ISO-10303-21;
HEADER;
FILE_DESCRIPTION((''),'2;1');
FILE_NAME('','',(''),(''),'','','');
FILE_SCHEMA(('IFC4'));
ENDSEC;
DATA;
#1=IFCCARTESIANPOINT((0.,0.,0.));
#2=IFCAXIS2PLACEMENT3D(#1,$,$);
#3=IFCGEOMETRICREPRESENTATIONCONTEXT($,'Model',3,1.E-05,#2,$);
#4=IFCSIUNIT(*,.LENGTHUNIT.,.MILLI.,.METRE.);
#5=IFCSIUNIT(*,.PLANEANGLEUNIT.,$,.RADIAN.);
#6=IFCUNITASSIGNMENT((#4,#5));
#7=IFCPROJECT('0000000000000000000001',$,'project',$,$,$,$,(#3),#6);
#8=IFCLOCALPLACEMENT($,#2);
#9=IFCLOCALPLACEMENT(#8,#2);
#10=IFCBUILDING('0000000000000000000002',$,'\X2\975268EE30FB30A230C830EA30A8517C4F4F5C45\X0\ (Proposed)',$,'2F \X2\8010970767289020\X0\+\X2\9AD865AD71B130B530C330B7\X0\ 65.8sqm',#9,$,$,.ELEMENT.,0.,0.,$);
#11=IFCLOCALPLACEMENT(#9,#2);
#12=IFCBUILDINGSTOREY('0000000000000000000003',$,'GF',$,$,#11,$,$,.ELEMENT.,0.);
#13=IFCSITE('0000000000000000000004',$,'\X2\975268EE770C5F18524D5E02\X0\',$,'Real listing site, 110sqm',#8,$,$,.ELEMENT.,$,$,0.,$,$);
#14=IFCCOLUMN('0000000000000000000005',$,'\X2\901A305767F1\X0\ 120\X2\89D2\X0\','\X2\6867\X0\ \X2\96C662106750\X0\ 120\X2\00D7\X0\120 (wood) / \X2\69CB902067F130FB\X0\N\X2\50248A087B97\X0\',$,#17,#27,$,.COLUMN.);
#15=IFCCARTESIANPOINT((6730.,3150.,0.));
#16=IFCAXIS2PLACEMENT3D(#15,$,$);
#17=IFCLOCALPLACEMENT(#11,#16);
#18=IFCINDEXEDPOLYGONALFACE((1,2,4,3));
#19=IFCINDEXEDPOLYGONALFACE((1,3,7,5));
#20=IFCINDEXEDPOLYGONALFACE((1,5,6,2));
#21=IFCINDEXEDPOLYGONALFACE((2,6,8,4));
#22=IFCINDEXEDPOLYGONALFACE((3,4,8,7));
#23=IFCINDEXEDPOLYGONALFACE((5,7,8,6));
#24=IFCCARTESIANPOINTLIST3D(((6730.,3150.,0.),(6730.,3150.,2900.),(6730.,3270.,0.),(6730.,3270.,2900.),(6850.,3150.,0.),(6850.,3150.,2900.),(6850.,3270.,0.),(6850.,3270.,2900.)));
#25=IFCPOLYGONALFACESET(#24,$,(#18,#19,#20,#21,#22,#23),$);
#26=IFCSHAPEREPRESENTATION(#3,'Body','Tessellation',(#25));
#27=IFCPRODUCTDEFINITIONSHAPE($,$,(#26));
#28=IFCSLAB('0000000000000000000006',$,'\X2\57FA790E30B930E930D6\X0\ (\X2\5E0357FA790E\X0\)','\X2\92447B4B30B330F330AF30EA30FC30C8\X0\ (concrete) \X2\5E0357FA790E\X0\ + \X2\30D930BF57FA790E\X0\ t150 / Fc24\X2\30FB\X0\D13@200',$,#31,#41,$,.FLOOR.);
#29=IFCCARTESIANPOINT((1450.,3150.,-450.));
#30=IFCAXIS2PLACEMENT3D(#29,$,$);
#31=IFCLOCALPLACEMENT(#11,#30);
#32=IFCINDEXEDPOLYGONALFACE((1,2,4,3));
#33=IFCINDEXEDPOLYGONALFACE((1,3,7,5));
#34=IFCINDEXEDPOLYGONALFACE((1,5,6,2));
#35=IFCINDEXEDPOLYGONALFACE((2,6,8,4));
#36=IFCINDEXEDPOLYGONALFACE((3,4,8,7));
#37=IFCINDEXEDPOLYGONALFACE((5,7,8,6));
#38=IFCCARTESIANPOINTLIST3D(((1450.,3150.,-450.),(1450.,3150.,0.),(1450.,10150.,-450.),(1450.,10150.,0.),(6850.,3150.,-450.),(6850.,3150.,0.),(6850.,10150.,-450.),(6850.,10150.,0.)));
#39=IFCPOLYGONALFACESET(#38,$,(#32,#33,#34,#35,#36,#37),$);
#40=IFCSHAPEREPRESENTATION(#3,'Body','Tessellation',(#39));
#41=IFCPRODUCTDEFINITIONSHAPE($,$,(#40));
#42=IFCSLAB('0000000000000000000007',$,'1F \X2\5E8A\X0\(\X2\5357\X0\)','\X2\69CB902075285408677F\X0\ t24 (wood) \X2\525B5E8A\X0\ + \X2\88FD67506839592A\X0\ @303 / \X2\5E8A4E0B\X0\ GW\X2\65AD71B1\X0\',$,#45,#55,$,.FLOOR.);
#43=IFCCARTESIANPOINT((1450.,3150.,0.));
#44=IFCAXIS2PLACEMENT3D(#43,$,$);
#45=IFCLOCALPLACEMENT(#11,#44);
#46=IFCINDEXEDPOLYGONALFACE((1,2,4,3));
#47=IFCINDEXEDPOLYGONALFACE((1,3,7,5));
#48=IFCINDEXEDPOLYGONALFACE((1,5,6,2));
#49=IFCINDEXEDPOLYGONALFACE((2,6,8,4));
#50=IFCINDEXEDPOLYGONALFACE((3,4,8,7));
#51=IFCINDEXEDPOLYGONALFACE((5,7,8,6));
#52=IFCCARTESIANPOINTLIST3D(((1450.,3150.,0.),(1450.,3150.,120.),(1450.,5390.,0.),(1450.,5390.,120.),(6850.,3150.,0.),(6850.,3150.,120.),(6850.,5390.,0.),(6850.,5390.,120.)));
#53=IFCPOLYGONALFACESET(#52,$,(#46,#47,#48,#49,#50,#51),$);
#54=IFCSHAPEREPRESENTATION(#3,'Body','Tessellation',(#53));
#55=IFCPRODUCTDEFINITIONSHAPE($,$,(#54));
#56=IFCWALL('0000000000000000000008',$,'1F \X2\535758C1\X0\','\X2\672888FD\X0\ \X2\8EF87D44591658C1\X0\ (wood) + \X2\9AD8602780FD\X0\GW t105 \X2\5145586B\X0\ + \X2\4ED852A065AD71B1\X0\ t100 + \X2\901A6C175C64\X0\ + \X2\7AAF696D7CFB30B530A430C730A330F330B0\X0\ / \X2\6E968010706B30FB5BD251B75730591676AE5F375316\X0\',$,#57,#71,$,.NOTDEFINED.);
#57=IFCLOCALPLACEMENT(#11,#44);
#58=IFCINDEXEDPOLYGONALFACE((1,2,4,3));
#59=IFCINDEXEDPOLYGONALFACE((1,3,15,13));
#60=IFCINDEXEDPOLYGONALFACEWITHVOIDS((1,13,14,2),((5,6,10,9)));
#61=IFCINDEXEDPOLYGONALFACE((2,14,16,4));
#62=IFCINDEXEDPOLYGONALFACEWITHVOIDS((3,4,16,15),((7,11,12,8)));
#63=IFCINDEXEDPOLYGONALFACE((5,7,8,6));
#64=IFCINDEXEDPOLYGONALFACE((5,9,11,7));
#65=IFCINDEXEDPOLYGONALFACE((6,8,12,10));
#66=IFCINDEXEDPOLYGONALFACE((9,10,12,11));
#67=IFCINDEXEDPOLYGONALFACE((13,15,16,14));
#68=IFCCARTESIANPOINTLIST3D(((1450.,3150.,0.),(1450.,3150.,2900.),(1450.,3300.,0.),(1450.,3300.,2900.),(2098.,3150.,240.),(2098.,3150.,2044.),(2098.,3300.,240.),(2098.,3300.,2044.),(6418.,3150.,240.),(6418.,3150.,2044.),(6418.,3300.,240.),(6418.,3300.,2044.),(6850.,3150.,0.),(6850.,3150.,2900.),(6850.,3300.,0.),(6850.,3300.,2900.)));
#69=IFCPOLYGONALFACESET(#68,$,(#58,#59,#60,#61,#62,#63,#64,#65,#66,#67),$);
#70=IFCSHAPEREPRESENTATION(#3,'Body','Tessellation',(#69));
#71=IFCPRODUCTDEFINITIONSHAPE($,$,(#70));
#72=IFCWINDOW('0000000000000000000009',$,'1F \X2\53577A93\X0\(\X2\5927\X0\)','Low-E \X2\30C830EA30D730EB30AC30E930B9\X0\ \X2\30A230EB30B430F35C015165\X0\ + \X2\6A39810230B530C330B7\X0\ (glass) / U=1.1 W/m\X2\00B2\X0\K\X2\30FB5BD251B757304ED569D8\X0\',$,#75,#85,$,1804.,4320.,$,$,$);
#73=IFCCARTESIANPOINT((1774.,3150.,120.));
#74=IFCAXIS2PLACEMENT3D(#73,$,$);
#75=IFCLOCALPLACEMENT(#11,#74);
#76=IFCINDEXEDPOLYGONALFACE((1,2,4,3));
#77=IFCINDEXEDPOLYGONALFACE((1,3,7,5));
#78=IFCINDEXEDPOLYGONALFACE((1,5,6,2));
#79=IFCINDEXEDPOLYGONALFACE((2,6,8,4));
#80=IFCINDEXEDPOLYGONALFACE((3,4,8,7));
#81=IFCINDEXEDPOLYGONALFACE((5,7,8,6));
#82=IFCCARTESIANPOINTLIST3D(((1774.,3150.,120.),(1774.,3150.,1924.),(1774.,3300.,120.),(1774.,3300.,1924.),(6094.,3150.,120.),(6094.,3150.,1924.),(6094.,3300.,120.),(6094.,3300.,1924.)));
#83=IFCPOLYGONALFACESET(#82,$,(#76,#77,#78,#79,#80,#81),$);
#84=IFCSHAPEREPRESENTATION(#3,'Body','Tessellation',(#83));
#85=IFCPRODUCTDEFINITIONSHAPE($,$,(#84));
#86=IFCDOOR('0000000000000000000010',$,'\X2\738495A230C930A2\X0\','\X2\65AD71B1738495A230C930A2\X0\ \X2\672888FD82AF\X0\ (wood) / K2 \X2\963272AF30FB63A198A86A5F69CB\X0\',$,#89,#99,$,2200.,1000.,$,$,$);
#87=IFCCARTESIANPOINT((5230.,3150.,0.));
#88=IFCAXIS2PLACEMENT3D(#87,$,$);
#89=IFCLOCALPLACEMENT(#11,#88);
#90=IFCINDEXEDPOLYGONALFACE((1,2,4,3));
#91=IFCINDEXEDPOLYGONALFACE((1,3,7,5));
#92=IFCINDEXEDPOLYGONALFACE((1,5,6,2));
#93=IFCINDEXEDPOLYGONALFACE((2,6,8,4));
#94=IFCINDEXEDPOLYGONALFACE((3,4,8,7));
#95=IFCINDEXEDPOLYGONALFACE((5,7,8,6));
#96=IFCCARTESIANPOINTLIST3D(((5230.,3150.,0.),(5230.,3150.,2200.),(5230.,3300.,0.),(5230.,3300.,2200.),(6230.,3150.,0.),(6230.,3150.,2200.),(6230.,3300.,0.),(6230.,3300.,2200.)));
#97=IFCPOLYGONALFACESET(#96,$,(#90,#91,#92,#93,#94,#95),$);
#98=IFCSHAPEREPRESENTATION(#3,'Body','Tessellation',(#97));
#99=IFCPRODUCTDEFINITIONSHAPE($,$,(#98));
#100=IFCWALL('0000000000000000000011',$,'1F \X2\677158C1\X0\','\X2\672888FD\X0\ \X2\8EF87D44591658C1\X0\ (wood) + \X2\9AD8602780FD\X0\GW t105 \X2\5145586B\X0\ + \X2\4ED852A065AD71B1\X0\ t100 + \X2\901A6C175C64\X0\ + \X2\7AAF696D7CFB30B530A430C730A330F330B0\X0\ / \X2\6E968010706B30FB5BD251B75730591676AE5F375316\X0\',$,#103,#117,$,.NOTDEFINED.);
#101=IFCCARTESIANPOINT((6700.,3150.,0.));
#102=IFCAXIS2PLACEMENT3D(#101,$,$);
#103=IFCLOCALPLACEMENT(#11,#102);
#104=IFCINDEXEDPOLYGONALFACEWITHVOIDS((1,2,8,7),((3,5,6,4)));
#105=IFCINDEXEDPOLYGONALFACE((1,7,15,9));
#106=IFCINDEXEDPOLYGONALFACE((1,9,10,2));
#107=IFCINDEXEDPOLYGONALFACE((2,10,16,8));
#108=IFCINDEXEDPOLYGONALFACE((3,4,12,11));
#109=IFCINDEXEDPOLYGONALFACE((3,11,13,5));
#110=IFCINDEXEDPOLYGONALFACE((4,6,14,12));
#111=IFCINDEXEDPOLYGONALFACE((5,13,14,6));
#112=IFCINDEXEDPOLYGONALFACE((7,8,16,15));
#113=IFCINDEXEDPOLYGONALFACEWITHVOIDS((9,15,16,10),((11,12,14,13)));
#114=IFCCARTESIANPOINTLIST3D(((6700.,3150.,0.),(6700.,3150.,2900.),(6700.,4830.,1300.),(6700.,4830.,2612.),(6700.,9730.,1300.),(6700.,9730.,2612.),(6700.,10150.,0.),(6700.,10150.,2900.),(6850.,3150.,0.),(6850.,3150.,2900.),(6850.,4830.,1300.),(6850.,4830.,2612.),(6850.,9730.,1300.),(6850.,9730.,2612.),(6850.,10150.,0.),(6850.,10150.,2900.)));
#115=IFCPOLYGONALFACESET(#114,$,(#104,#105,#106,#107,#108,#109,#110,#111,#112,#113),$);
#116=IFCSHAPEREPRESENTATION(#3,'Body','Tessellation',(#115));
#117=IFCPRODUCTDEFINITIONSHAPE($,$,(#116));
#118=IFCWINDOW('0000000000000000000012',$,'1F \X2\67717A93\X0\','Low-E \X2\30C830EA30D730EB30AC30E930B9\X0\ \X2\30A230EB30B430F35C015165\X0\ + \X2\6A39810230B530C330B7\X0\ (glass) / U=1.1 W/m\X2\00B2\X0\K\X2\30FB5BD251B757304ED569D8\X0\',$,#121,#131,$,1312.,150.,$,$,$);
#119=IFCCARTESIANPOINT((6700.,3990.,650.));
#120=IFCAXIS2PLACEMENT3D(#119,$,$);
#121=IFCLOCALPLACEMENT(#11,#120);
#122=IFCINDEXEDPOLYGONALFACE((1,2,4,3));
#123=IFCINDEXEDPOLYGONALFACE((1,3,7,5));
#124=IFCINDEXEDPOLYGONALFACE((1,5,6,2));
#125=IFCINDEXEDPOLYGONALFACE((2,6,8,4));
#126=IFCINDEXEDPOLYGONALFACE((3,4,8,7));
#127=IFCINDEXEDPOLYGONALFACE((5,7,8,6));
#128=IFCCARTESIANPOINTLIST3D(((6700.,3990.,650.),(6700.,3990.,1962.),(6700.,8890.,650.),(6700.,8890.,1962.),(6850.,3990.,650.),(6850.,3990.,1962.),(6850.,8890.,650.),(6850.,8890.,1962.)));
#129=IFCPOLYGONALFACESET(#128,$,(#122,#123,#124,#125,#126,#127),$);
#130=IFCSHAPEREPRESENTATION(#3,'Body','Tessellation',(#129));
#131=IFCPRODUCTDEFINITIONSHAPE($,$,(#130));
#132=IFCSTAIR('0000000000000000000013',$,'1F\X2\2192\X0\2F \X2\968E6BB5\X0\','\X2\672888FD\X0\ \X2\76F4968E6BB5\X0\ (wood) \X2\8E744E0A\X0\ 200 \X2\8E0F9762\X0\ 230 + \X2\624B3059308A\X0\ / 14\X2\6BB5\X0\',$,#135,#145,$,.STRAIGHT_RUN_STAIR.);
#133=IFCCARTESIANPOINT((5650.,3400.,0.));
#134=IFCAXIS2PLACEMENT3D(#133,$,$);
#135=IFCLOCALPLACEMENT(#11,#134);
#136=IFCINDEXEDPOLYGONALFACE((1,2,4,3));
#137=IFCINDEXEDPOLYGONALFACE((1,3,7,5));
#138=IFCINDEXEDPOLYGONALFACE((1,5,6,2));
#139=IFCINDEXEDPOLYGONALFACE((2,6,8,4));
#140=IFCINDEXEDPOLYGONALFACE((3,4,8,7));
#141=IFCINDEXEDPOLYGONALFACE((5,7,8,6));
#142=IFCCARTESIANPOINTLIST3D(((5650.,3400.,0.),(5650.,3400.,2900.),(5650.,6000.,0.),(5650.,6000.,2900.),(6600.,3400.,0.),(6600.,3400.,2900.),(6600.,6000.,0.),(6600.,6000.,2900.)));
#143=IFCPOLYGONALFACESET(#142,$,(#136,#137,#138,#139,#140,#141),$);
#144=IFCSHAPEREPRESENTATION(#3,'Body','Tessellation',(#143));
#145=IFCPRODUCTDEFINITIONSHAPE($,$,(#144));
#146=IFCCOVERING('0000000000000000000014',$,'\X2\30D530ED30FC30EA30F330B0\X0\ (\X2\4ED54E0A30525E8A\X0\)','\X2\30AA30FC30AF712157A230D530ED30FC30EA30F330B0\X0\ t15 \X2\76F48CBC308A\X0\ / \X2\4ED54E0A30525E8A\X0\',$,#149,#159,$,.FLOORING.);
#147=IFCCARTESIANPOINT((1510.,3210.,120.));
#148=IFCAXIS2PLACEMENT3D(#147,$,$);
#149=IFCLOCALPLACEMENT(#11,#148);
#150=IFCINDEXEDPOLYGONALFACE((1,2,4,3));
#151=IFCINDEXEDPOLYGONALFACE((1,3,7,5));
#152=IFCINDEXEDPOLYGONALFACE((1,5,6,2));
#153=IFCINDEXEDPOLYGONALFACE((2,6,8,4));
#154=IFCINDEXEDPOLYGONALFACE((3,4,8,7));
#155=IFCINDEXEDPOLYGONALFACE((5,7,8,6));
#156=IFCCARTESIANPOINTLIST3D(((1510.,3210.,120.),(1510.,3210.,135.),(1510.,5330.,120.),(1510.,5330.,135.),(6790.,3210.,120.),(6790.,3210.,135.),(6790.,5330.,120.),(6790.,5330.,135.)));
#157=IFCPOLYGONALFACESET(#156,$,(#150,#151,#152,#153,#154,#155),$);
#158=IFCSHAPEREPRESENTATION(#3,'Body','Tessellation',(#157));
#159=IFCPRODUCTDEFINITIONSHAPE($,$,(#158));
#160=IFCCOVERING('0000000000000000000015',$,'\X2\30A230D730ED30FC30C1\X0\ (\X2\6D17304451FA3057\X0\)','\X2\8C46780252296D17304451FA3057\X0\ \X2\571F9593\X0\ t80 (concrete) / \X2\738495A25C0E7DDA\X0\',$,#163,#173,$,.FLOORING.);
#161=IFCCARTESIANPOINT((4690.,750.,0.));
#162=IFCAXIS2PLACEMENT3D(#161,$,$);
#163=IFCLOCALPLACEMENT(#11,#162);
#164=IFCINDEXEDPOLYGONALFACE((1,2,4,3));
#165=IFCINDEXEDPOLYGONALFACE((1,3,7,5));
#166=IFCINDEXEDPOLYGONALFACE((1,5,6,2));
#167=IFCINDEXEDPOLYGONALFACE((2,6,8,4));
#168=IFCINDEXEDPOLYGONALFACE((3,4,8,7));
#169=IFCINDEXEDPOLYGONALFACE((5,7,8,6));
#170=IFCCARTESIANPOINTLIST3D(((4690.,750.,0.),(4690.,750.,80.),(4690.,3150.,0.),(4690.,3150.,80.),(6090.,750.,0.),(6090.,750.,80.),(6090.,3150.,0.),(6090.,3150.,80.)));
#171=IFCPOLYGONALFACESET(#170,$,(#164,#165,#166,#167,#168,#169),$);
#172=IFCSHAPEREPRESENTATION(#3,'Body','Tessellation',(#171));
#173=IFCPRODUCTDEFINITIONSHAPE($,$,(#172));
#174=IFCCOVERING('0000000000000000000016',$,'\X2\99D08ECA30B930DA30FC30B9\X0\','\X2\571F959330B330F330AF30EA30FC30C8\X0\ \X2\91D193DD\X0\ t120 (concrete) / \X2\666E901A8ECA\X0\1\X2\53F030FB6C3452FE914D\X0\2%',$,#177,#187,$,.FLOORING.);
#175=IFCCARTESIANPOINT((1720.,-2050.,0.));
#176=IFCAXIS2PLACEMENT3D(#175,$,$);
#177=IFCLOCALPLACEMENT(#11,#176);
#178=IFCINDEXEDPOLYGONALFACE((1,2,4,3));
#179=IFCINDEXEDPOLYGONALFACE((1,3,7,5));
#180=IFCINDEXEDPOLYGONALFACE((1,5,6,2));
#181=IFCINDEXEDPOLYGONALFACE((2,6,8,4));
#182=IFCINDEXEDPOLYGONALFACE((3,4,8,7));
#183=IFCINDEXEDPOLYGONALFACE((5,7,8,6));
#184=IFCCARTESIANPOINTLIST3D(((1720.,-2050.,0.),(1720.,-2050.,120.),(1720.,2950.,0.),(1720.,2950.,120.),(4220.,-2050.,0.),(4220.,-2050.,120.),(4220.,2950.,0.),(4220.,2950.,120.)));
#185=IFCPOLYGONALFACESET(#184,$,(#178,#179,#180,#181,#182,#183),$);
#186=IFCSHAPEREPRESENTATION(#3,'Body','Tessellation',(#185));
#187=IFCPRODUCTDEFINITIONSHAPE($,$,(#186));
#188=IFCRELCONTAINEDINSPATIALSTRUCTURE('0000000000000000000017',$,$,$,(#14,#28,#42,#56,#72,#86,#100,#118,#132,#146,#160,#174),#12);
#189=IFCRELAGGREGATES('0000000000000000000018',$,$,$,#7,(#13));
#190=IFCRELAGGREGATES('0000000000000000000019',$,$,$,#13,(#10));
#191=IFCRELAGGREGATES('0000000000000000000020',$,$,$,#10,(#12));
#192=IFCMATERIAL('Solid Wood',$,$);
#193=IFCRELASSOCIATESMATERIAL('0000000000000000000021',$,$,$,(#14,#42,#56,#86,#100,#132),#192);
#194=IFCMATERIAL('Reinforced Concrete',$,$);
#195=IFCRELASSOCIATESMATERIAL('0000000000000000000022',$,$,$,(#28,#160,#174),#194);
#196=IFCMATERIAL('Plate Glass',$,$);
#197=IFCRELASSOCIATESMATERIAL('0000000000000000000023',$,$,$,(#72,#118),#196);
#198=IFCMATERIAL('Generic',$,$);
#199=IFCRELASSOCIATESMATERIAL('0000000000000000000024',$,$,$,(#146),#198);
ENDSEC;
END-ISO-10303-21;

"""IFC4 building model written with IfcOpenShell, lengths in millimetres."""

from ifc_helpers import new_model, si_unit, frame, frame_2d, origin, place, context, project, spatial, rectangle, extrude, material, element, fill, save


model = new_model("IFC4")

# Units and contexts
model_context = context("Model", 3, precision=1e-05, world=origin())
ifc_project = project(units=[si_unit("LENGTHUNIT", "METRE", prefix="MILLI"), si_unit("PLANEANGLEUNIT", "RADIAN")], contexts=[model_context])

# Site, building, storey
site_placement = place(None, origin())
site = spatial("IfcSite", under=ifc_project, at=site_placement, Name="青森県弘前市", ObjectType="Real listing site, 110sqm", CompositionType="ELEMENT", RefElevation=0.0)
building_placement = place(site_placement, origin())
building = spatial("IfcBuilding", under=site, at=building_placement, Name="青森・アトリエ兼住居 (Proposed)", ObjectType="2F 耐震木造+高断熱サッシ 65.8sqm", CompositionType="ELEMENT", ElevationOfRefHeight=0.0, ElevationOfTerrain=0.0)
storey_placement = place(building_placement, origin())
storey = spatial("IfcBuildingStorey", under=building, at=storey_placement, Name="GF", CompositionType="ELEMENT", Elevation=0.0)

# Column
ifc_material_1 = material(Name="Solid Wood")
column_1_placement = place(storey_placement, frame((6730.0, 3150.0, 0.0)))
element("IfcColumn", 1, at=column_1_placement, inside=storey, material=ifc_material_1, Name="通し柱 120角", Description="桧 集成材 120×120 (wood) / 構造柱・N値計算", PredefinedType="COLUMN", context=model_context, shape_type="SweptSolid", body=[
    extrude(rectangle(XDim=120.0, YDim=120.0, at=frame_2d((60.0, 60.0))), frame((6730.0, 3150.0, 0.0)), (0.0, 0.0, 1.0), 2900.0),
])

# Slabs
ifc_material_2 = material(Name="Reinforced Concrete")
slab_1_placement = place(storey_placement, frame((1450.0, 3150.0, -450.0)))
element("IfcSlab", 2, at=slab_1_placement, inside=storey, material=ifc_material_2, Name="基礎スラブ (布基礎)", Description="鉄筋コンクリート (concrete) 布基礎 + ベタ基礎 t150 / Fc24・D13@200", PredefinedType="FLOOR", context=model_context, shape_type="SweptSolid", body=[
    extrude(rectangle(XDim=5400.0, YDim=7000.0, at=frame_2d((2700.0, 3500.0))), frame((1450.0, 3150.0, -450.0)), (0.0, 0.0, 1.0), 450.0),
])
slab_2_placement = place(storey_placement, frame((1450.0, 3150.0, 0.0)))
element("IfcSlab", 3, at=slab_2_placement, inside=storey, material=ifc_material_1, Name="1F 床(南)", Description="構造用合板 t24 (wood) 剛床 + 製材根太 @303 / 床下 GW断熱", PredefinedType="FLOOR", context=model_context, shape_type="SweptSolid", body=[
    extrude(rectangle(XDim=5400.0, YDim=2240.0, at=frame_2d((2700.0, 1120.0))), frame((1450.0, 3150.0, 0.0)), (0.0, 0.0, 1.0), 120.0),
])

# Wall, openings, window, door
wall_1_placement = place(storey_placement, frame((1450.0, 3150.0, 0.0)))
wall_1 = element("IfcWall", 4, at=wall_1_placement, inside=storey, material=ifc_material_1, Name="1F 南壁", Description="木製 軸組外壁 (wood) + 高性能GW t105 充填 + 付加断熱 t100 + 通気層 + 窯業系サイディング / 準耐火・寒冷地外皮強化", PredefinedType="NOTDEFINED", context=model_context, shape_type="SweptSolid", body=[
    extrude(rectangle(XDim=5400.0, YDim=150.0, at=frame_2d((2700.0, 75.0))), frame((1450.0, 3150.0, 0.0)), (0.0, 0.0, 1.0), 2900.0),
])
opening_1_placement = place(storey_placement, frame((1774.0, 3150.0, 120.0)))
opening_1 = element("IfcOpeningElement", 5, at=opening_1_placement, cuts=wall_1, PredefinedType="NOTDEFINED", context=model_context, shape_type="SweptSolid", body=[
    extrude(rectangle(XDim=4320.0, YDim=150.0, at=frame_2d((2160.0, 75.0))), frame((1774.0, 3150.0, 120.0)), (0.0, 0.0, 1.0), 1804.0),
])
opening_2_placement = place(storey_placement, frame((5230.0, 3150.0, 0.0)))
opening_2 = element("IfcOpeningElement", 6, at=opening_2_placement, cuts=wall_1, PredefinedType="NOTDEFINED", context=model_context, shape_type="SweptSolid", body=[
    extrude(rectangle(XDim=1000.0, YDim=150.0, at=frame_2d((500.0, 75.0))), frame((5230.0, 3150.0, 0.0)), (0.0, 0.0, 1.0), 2200.0),
])
ifc_material_3 = material(Name="Plate Glass")
window_1_placement = place(storey_placement, frame((1774.0, 3150.0, 120.0)))
window_1 = element("IfcWindow", 7, at=window_1_placement, inside=storey, material=ifc_material_3, Name="1F 南窓(大)", Description="Low-E トリプルガラス アルゴン封入 + 樹脂サッシ (glass) / U=1.1 W/m²K・寒冷地仕様", OverallHeight=1804.0, OverallWidth=4320.0, context=model_context, shape_type="SweptSolid", body=[
    extrude(rectangle(XDim=4320.0, YDim=150.0, at=frame_2d((2160.0, 75.0))), frame((1774.0, 3150.0, 120.0)), (0.0, 0.0, 1.0), 1804.0),
])
fill(opening_1, window_1)
door_placement = place(storey_placement, frame((5230.0, 3150.0, 0.0)))
door = element("IfcDoor", 8, at=door_placement, inside=storey, material=ifc_material_1, Name="玄関ドア", Description="断熱玄関ドア 木製芯 (wood) / K2 防犯・採風機構", OverallHeight=2200.0, OverallWidth=1000.0, context=model_context, shape_type="SweptSolid", body=[
    extrude(rectangle(XDim=1000.0, YDim=150.0, at=frame_2d((500.0, 75.0))), frame((5230.0, 3150.0, 0.0)), (0.0, 0.0, 1.0), 2200.0),
])
fill(opening_2, door)

# Wall, opening, window
wall_2_placement = place(storey_placement, frame((6700.0, 3150.0, 0.0)))
wall_2 = element("IfcWall", 9, at=wall_2_placement, inside=storey, material=ifc_material_1, Name="1F 東壁", Description="木製 軸組外壁 (wood) + 高性能GW t105 充填 + 付加断熱 t100 + 通気層 + 窯業系サイディング / 準耐火・寒冷地外皮強化", PredefinedType="NOTDEFINED", context=model_context, shape_type="SweptSolid", body=[
    extrude(rectangle(XDim=150.0, YDim=7000.0, at=frame_2d((75.0, 3500.0))), frame((6700.0, 3150.0, 0.0)), (0.0, 0.0, 1.0), 2900.0),
])
opening_3_placement = place(storey_placement, frame((6700.0, 3990.0, 650.0)))
opening_3 = element("IfcOpeningElement", 10, at=opening_3_placement, cuts=wall_2, PredefinedType="NOTDEFINED", context=model_context, shape_type="SweptSolid", body=[
    extrude(rectangle(XDim=150.0, YDim=4900.0, at=frame_2d((75.0, 2450.0))), frame((6700.0, 3990.0, 650.0)), (0.0, 0.0, 1.0), 1312.0),
])
window_2_placement = place(storey_placement, frame((6700.0, 3990.0, 650.0)))
window_2 = element("IfcWindow", 11, at=window_2_placement, inside=storey, material=ifc_material_3, Name="1F 東窓", Description="Low-E トリプルガラス アルゴン封入 + 樹脂サッシ (glass) / U=1.1 W/m²K・寒冷地仕様", OverallHeight=1312.0, OverallWidth=150.0, context=model_context, shape_type="SweptSolid", body=[
    extrude(rectangle(XDim=150.0, YDim=4900.0, at=frame_2d((75.0, 2450.0))), frame((6700.0, 3990.0, 650.0)), (0.0, 0.0, 1.0), 1312.0),
])
fill(opening_3, window_2)

# Stair
stair_placement = place(storey_placement, frame((5650.0, 3400.0, 0.0)))
element("IfcStair", 12, at=stair_placement, inside=storey, material=ifc_material_1, Name="1F→2F 階段", Description="木製 直階段 (wood) 蹴上 200 踏面 230 + 手すり / 14段", PredefinedType="STRAIGHT_RUN_STAIR", context=model_context, shape_type="SweptSolid", body=[
    extrude(rectangle(XDim=950.0, YDim=2600.0, at=frame_2d((475.0, 1300.0))), frame((5650.0, 3400.0, 0.0)), (0.0, 0.0, 1.0), 2900.0),
])

# Coverings
ifc_material_4 = material(Name="Generic")
covering_1_placement = place(storey_placement, frame((1510.0, 3210.0, 120.0)))
element("IfcCovering", 13, at=covering_1_placement, inside=storey, material=ifc_material_4, Name="フローリング (仕上げ床)", Description="オーク無垢フローリング t15 直貼り / 仕上げ床", PredefinedType="FLOORING", context=model_context, shape_type="SweptSolid", body=[
    extrude(rectangle(XDim=5280.0, YDim=2120.0, at=frame_2d((2640.0, 1060.0))), frame((1510.0, 3210.0, 120.0)), (0.0, 0.0, 1.0), 15.0),
])
covering_2_placement = place(storey_placement, frame((4690.0, 750.0, 0.0)))
element("IfcCovering", 14, at=covering_2_placement, inside=storey, material=ifc_material_2, Name="アプローチ (洗い出し)", Description="豆砂利洗い出し 土間 t80 (concrete) / 玄関導線", PredefinedType="FLOORING", context=model_context, shape_type="SweptSolid", body=[
    extrude(rectangle(XDim=1400.0, YDim=2400.0, at=frame_2d((700.0, 1200.0))), frame((4690.0, 750.0, 0.0)), (0.0, 0.0, 1.0), 80.0),
])
covering_3_placement = place(storey_placement, frame((1720.0, -2050.0, 0.0)))
element("IfcCovering", 15, at=covering_3_placement, inside=storey, material=ifc_material_2, Name="駐車スペース", Description="土間コンクリート 金鏝 t120 (concrete) / 普通車1台・水勾配2%", PredefinedType="FLOORING", context=model_context, shape_type="SweptSolid", body=[
    extrude(rectangle(XDim=2500.0, YDim=5000.0, at=frame_2d((1250.0, 2500.0))), frame((1720.0, -2050.0, 0.0)), (0.0, 0.0, 1.0), 120.0),
])

save(model, "model.ifc")
